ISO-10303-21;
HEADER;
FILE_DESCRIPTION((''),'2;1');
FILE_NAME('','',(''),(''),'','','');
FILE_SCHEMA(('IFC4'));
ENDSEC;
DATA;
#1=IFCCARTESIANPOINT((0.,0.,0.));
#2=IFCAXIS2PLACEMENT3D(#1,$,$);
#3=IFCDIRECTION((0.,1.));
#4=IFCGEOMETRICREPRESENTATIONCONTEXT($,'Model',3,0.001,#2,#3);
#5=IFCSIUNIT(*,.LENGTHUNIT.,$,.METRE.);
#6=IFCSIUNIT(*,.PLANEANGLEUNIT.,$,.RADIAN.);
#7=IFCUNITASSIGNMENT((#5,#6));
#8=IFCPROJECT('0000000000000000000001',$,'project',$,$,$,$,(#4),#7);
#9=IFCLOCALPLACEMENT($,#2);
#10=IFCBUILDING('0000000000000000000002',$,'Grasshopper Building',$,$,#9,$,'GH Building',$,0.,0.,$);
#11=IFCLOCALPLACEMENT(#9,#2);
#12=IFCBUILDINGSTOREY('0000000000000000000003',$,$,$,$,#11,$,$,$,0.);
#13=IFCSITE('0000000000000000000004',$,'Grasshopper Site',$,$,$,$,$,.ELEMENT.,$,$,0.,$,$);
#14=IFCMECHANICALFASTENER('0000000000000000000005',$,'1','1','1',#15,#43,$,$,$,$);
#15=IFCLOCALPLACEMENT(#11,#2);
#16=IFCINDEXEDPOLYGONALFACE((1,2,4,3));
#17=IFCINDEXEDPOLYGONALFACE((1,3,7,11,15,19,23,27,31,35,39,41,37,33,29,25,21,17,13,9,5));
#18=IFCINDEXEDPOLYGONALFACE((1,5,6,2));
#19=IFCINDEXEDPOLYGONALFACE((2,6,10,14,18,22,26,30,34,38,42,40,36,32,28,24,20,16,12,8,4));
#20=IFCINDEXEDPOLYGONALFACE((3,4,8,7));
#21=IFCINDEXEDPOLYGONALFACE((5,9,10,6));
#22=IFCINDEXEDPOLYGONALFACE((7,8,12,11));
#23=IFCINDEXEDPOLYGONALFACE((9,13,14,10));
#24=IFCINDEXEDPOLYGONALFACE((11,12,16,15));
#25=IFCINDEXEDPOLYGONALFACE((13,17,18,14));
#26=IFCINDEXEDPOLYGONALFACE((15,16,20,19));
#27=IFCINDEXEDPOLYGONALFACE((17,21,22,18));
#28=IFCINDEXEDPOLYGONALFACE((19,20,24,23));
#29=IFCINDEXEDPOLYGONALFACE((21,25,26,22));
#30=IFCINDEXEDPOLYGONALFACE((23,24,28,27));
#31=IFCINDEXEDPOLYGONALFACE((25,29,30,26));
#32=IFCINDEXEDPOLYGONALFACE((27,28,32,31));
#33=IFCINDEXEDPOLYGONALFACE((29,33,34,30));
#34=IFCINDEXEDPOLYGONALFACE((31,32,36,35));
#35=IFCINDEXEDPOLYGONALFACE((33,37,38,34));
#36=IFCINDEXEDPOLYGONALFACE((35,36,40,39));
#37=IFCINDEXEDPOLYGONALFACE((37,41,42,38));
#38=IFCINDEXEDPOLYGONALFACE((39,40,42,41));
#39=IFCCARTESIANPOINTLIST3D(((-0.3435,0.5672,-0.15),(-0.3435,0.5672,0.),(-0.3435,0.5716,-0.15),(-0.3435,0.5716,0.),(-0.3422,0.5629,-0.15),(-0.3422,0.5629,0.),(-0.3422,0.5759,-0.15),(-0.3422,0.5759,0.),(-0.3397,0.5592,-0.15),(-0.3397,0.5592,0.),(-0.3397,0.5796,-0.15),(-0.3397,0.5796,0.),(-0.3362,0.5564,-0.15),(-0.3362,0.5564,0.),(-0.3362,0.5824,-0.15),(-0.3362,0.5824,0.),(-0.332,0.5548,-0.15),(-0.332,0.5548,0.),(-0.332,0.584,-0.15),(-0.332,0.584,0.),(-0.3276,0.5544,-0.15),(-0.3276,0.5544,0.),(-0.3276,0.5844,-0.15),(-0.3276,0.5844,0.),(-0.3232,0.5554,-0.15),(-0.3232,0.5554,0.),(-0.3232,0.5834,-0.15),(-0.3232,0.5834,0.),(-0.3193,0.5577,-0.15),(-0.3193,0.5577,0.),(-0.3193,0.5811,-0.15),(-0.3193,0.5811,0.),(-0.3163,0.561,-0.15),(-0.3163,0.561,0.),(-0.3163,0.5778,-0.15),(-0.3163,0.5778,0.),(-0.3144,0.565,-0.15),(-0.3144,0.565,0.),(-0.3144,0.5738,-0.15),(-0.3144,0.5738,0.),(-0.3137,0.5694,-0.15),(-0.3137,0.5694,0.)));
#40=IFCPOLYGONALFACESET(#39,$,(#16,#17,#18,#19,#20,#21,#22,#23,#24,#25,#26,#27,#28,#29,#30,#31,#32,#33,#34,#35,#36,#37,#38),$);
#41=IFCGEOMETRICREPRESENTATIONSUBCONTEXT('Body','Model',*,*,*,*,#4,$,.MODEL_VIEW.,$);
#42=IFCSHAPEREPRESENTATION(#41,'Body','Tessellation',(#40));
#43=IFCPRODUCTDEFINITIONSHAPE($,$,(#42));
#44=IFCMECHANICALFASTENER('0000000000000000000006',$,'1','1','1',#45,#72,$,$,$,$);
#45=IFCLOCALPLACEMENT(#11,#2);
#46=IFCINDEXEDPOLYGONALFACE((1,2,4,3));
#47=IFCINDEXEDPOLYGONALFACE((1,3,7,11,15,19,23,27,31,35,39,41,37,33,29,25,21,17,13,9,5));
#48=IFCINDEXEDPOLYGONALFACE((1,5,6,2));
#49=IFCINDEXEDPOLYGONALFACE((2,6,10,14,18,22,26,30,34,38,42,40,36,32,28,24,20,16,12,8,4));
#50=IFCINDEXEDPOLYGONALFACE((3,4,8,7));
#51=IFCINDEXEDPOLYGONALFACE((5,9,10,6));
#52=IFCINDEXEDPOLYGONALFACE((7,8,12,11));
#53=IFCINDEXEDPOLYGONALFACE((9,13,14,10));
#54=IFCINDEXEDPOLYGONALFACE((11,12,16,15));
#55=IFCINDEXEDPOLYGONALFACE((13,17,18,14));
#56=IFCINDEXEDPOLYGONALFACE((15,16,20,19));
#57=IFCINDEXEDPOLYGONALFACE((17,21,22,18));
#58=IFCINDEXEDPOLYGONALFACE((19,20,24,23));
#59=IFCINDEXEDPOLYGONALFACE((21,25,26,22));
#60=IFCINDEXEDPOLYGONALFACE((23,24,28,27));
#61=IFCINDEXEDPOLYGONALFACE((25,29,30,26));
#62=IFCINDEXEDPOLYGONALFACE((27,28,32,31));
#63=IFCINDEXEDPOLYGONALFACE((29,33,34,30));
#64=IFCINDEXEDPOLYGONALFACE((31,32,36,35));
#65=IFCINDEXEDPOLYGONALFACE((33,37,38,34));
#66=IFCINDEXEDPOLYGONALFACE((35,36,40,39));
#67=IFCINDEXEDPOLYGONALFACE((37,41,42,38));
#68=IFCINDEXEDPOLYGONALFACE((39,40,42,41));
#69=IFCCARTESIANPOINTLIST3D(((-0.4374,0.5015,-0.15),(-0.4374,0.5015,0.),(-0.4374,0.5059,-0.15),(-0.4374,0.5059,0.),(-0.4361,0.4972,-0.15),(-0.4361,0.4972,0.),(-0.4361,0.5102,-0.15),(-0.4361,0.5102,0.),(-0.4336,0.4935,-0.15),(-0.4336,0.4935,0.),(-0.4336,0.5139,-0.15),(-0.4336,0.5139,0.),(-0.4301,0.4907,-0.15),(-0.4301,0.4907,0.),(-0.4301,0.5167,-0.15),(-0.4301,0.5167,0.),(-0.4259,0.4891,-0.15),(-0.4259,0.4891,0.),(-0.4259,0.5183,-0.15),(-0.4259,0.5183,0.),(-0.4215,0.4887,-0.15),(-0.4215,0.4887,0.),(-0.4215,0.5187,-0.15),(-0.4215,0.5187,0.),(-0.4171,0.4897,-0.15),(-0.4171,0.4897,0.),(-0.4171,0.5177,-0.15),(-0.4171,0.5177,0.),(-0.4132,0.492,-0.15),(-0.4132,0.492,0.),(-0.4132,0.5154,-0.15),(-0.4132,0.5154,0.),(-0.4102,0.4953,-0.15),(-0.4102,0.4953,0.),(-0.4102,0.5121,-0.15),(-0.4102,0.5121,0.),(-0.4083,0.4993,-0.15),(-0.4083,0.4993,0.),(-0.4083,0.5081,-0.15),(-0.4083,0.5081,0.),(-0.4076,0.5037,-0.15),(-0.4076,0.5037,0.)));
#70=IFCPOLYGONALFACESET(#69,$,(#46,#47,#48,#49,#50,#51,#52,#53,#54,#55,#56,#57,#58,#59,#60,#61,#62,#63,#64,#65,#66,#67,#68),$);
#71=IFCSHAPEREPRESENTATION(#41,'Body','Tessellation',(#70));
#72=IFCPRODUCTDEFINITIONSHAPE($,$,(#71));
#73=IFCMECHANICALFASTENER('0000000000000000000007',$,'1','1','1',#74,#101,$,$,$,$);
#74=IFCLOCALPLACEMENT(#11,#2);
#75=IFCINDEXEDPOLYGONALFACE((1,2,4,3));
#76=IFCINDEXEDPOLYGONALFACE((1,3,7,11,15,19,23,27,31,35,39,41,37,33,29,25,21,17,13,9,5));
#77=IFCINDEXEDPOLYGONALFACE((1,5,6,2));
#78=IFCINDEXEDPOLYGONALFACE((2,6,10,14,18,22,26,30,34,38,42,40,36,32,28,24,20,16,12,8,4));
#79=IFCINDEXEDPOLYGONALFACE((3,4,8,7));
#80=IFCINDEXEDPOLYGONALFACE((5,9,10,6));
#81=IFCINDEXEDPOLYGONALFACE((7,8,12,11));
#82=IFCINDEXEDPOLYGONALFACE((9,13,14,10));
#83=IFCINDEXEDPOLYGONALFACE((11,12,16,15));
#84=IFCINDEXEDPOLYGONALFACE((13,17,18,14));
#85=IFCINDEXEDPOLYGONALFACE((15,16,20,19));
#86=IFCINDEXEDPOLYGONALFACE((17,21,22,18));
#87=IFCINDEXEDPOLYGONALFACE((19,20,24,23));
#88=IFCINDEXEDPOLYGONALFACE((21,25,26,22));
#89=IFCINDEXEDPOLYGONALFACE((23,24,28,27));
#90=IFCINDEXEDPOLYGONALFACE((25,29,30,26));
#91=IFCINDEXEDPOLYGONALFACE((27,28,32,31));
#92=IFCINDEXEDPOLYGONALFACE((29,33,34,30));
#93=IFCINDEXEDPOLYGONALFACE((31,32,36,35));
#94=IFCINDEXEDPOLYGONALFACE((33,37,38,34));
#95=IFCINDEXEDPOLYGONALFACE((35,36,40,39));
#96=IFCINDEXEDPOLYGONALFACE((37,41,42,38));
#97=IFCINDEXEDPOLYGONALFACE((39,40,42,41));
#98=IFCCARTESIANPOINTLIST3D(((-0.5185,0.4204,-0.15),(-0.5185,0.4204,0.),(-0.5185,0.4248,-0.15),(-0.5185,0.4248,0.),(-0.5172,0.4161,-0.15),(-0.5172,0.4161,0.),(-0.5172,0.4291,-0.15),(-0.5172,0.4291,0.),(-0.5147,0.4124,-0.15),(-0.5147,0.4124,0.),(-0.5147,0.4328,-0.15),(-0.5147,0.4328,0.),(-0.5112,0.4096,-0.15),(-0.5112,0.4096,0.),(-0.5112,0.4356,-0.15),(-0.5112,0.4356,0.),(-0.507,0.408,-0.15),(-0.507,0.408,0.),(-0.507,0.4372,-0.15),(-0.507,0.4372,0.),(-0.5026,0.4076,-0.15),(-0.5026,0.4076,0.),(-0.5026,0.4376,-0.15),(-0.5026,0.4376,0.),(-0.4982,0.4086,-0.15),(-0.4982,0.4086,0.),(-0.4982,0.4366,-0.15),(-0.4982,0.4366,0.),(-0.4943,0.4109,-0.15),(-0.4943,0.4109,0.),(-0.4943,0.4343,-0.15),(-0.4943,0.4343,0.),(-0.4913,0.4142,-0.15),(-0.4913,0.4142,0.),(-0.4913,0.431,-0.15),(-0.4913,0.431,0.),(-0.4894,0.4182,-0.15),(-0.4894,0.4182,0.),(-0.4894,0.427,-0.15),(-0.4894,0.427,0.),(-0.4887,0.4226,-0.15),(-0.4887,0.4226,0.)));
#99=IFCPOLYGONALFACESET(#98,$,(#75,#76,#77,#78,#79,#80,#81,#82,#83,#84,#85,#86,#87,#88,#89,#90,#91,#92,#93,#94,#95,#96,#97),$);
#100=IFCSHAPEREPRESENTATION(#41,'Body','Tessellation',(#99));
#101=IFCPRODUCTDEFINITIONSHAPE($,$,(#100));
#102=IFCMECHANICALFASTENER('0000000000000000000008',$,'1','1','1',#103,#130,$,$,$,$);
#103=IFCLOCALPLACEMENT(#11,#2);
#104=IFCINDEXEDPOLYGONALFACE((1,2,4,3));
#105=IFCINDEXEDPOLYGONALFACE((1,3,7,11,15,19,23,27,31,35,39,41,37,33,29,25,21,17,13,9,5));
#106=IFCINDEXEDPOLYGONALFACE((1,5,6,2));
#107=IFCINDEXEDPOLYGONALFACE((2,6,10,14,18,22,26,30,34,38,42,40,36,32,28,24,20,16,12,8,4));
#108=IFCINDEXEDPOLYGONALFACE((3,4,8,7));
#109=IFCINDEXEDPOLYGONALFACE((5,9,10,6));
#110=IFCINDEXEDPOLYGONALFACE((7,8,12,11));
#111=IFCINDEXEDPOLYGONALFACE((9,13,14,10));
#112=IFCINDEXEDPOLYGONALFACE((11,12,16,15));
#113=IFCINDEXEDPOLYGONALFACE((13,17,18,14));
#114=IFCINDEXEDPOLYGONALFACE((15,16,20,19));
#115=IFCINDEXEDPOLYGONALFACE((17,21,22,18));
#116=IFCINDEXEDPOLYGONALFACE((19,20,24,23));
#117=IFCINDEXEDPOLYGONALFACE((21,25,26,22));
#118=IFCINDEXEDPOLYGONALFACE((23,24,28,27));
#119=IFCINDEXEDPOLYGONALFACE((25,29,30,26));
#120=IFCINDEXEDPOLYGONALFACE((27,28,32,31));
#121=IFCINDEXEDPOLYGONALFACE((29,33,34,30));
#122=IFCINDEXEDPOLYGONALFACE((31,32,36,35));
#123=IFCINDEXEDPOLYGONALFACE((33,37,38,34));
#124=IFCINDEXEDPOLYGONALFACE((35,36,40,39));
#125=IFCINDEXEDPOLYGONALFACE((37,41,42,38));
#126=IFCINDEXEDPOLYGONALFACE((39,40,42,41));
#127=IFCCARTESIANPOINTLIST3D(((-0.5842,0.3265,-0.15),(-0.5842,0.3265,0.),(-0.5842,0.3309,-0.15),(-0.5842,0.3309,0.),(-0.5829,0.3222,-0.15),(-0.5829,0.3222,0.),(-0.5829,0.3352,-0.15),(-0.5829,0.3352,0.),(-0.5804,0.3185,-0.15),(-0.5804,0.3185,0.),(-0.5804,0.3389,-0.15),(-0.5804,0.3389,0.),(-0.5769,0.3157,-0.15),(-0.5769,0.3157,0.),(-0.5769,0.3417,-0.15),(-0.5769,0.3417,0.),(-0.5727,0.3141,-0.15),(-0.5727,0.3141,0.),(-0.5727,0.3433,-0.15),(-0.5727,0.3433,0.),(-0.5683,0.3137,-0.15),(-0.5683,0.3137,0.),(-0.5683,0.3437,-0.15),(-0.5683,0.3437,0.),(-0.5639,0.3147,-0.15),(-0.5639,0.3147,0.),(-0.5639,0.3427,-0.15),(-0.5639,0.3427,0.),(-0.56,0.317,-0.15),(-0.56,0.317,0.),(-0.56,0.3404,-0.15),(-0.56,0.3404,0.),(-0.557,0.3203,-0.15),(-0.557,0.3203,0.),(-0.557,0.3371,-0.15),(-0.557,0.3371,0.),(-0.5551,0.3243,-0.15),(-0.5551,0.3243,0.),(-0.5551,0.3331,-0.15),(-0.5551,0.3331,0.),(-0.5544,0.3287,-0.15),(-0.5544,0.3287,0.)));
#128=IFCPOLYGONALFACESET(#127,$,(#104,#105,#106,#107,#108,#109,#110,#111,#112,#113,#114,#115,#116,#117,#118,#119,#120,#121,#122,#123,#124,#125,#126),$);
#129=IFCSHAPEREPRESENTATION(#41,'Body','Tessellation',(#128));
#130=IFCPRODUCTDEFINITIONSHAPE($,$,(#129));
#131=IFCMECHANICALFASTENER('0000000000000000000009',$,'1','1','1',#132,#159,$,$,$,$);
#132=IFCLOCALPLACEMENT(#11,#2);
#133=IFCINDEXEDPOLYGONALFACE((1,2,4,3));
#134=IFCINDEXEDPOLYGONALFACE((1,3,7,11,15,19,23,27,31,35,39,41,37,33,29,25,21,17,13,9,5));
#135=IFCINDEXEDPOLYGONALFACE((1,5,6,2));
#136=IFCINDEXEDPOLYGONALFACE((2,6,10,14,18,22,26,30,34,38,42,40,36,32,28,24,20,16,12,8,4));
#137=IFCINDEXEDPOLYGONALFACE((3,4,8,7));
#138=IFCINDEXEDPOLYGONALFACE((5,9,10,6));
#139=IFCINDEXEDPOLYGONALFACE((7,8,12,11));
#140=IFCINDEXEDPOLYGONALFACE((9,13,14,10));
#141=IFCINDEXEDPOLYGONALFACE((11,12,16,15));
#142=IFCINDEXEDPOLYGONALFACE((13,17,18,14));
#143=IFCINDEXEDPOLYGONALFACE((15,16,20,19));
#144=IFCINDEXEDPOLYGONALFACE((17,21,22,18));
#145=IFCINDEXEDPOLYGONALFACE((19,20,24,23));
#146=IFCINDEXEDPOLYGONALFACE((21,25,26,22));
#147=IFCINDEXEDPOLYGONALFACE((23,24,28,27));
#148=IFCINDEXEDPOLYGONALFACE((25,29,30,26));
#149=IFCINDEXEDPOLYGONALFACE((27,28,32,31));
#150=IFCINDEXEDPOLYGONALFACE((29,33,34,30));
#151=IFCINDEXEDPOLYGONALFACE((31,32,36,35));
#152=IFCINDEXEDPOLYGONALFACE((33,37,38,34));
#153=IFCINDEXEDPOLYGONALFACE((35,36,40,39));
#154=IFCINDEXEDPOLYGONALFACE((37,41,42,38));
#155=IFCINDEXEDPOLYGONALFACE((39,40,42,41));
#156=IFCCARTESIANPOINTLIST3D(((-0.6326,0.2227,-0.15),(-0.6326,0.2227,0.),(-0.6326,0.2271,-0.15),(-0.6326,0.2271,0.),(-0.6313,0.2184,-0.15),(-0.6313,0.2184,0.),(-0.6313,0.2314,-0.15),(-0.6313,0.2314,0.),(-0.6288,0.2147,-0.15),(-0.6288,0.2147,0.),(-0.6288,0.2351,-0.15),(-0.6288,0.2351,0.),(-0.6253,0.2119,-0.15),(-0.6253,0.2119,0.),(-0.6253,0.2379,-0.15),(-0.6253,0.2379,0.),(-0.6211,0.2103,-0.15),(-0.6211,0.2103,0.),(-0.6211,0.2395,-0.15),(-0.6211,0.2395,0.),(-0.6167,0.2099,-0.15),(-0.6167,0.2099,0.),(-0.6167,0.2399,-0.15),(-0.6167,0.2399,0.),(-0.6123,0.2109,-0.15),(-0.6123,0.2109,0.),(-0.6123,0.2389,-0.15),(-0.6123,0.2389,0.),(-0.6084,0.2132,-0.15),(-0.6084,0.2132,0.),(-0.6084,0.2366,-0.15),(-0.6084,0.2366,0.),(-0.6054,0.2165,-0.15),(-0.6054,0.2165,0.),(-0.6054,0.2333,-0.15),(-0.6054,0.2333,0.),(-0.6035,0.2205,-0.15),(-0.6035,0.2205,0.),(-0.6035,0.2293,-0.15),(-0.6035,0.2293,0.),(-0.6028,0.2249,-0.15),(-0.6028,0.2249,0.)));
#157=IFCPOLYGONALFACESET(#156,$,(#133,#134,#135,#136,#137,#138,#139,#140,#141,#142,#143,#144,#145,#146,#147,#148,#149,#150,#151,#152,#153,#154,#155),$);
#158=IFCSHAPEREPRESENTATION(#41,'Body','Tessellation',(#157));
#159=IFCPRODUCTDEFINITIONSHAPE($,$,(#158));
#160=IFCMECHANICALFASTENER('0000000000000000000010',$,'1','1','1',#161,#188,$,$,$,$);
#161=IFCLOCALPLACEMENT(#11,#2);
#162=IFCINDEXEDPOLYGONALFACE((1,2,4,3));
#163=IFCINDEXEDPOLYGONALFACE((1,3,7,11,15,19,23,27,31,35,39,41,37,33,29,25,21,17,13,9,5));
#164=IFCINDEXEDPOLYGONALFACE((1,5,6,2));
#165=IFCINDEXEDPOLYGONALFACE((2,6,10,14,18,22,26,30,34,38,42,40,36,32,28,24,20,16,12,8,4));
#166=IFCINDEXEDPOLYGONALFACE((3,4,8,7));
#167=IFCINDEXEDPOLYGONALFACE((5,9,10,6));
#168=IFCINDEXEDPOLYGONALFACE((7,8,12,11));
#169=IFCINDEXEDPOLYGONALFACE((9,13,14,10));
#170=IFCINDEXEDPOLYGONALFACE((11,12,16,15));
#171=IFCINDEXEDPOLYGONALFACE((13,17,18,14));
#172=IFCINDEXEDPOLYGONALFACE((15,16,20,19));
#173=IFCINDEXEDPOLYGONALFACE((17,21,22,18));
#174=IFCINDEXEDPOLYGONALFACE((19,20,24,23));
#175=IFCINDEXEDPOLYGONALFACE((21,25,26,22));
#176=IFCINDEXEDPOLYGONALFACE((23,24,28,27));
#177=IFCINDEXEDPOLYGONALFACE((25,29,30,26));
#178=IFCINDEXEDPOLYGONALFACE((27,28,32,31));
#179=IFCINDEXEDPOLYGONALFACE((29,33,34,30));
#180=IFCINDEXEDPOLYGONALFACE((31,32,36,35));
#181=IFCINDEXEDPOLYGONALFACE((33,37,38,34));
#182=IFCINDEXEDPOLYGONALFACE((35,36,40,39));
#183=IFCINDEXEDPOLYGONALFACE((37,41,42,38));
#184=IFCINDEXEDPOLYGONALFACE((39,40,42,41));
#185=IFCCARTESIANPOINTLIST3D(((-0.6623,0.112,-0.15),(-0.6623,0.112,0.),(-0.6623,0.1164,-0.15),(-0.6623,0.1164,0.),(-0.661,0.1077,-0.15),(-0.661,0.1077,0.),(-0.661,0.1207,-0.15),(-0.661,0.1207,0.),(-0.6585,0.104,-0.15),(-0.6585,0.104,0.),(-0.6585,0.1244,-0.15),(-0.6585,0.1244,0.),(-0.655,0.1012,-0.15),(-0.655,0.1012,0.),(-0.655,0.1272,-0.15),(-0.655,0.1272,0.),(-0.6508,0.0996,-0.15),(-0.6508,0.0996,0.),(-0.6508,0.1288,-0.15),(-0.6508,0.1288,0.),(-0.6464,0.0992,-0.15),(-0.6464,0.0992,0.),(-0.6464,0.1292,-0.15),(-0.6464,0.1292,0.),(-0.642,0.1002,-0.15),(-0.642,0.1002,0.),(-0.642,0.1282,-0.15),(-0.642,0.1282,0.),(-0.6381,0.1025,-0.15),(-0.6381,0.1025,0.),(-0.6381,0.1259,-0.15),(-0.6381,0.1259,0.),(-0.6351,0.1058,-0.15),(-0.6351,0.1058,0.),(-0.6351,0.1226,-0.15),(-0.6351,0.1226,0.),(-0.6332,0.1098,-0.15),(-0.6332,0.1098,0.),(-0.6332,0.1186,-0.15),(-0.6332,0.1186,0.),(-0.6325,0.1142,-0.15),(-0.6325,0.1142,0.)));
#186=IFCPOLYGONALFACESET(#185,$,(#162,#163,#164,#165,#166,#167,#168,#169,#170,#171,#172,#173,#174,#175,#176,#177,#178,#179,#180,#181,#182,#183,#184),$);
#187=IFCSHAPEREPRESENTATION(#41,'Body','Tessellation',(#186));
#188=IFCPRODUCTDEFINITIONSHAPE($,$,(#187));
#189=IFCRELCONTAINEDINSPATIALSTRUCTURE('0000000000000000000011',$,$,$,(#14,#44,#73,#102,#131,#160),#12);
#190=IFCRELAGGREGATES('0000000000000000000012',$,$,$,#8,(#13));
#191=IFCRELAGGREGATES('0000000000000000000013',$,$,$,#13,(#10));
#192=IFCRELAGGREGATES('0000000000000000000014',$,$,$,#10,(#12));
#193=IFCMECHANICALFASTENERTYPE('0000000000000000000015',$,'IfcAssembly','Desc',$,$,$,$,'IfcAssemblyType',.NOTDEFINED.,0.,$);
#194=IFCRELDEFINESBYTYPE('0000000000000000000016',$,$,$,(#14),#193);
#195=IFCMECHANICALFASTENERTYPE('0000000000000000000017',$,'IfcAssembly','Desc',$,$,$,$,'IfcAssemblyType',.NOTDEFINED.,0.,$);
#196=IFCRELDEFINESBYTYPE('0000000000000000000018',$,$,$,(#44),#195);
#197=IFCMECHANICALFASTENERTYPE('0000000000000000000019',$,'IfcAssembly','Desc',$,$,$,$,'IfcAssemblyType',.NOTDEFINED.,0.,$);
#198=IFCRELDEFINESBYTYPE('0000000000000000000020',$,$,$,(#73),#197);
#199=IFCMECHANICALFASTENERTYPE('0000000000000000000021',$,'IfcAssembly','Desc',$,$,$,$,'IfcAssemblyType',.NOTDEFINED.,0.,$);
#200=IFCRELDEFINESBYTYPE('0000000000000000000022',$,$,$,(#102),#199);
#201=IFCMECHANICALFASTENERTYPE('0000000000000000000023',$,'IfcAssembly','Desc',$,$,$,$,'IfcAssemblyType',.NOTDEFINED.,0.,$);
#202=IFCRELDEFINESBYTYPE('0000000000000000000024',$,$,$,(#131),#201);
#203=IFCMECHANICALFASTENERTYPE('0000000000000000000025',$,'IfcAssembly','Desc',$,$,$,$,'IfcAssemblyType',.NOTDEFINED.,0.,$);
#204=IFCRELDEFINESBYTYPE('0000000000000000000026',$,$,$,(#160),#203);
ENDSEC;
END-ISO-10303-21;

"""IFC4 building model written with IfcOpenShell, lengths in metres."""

from ifc_helpers import new_model, si_unit, direction, frame, origin, place, context, subcontext, project, spatial, circle, extrude, source, transform, mapped, type_object, type_shapes, element, save


model = new_model("IFC4")

# Units and contexts
model_context = context("Model", 3, precision=0.001, world=origin(), true_north=direction((0.0, 1.0)))
body_context = subcontext(model_context, "Body", "Model", "MODEL_VIEW")
ifc_project = project(units=[si_unit("LENGTHUNIT", "METRE"), si_unit("PLANEANGLEUNIT", "RADIAN")], contexts=[model_context])

# Site, building, storey
site = spatial("IfcSite", under=ifc_project, Name="Grasshopper Site", CompositionType="ELEMENT", RefElevation=0.0)
building_placement = place(None, origin())
building = spatial("IfcBuilding", under=site, at=building_placement, Name="Grasshopper Building", LongName="GH Building", ElevationOfRefHeight=0.0, ElevationOfTerrain=0.0)
storey_placement = place(building_placement, origin())
storey = spatial("IfcBuildingStorey", under=building, at=storey_placement, Elevation=0.0)

# Mechanical fasteners
mechanical_fastener_type_1 = type_object("IfcMechanicalFastenerType", Name="IfcAssembly", Description="Desc", ElementType="IfcAssemblyType", NominalDiameter=0.0)
shared_shape_1 = source(origin(), body_context, "Body", "SweptSolid", [
    extrude(circle(Radius=0.015), frame((-0.3287, 0.5694, 0.0), z_axis=(0.0, 0.0, -1.0), x_axis=(1.0, 0.0, 0.0)), (0.0, 0.0, 1.0), 0.15),
])
type_shapes(mechanical_fastener_type_1, [shared_shape_1])
mechanical_fastener_1_placement = place(storey_placement, origin())
element("IfcMechanicalFastener", 1, at=mechanical_fastener_1_placement, inside=storey, type_object=mechanical_fastener_type_1, Name="1", Description="1", ObjectType="1", context=body_context, shape_type="MappedRepresentation", body=[
    mapped(shared_shape_1, transform((0.0, 0.0, 0.0), scale=1.0)),
])
mechanical_fastener_type_2 = type_object("IfcMechanicalFastenerType", Name="IfcAssembly", Description="Desc", ElementType="IfcAssemblyType", NominalDiameter=0.0)
shared_shape_2 = source(origin(), body_context, "Body", "SweptSolid", [
    extrude(circle(Radius=0.015), frame((-0.4226, 0.5037, 0.0), z_axis=(0.0, 0.0, -1.0), x_axis=(1.0, 0.0, 0.0)), (0.0, 0.0, 1.0), 0.15),
])
type_shapes(mechanical_fastener_type_2, [shared_shape_2])
mechanical_fastener_2_placement = place(storey_placement, origin())
element("IfcMechanicalFastener", 2, at=mechanical_fastener_2_placement, inside=storey, type_object=mechanical_fastener_type_2, Name="1", Description="1", ObjectType="1", context=body_context, shape_type="MappedRepresentation", body=[
    mapped(shared_shape_2, transform((0.0, 0.0, 0.0), scale=1.0)),
])
mechanical_fastener_type_3 = type_object("IfcMechanicalFastenerType", Name="IfcAssembly", Description="Desc", ElementType="IfcAssemblyType", NominalDiameter=0.0)
shared_shape_3 = source(origin(), body_context, "Body", "SweptSolid", [
    extrude(circle(Radius=0.015), frame((-0.5037, 0.4226, 0.0), z_axis=(0.0, 0.0, -1.0), x_axis=(1.0, 0.0, 0.0)), (0.0, 0.0, 1.0), 0.15),
])
type_shapes(mechanical_fastener_type_3, [shared_shape_3])
mechanical_fastener_3_placement = place(storey_placement, origin())
element("IfcMechanicalFastener", 3, at=mechanical_fastener_3_placement, inside=storey, type_object=mechanical_fastener_type_3, Name="1", Description="1", ObjectType="1", context=body_context, shape_type="MappedRepresentation", body=[
    mapped(shared_shape_3, transform((0.0, 0.0, 0.0), scale=1.0)),
])
mechanical_fastener_type_4 = type_object("IfcMechanicalFastenerType", Name="IfcAssembly", Description="Desc", ElementType="IfcAssemblyType", NominalDiameter=0.0)
shared_shape_4 = source(origin(), body_context, "Body", "SweptSolid", [
    extrude(circle(Radius=0.015), frame((-0.5694, 0.3287, 0.0), z_axis=(0.0, 0.0, -1.0), x_axis=(1.0, 0.0, 0.0)), (0.0, 0.0, 1.0), 0.15),
])
type_shapes(mechanical_fastener_type_4, [shared_shape_4])
mechanical_fastener_4_placement = place(storey_placement, origin())
element("IfcMechanicalFastener", 4, at=mechanical_fastener_4_placement, inside=storey, type_object=mechanical_fastener_type_4, Name="1", Description="1", ObjectType="1", context=body_context, shape_type="MappedRepresentation", body=[
    mapped(shared_shape_4, transform((0.0, 0.0, 0.0), scale=1.0)),
])
mechanical_fastener_type_5 = type_object("IfcMechanicalFastenerType", Name="IfcAssembly", Description="Desc", ElementType="IfcAssemblyType", NominalDiameter=0.0)
shared_shape_5 = source(origin(), body_context, "Body", "SweptSolid", [
    extrude(circle(Radius=0.015), frame((-0.6178, 0.2249, 0.0), z_axis=(0.0, 0.0, -1.0), x_axis=(1.0, 0.0, 0.0)), (0.0, 0.0, 1.0), 0.15),
])
type_shapes(mechanical_fastener_type_5, [shared_shape_5])
mechanical_fastener_5_placement = place(storey_placement, origin())
element("IfcMechanicalFastener", 5, at=mechanical_fastener_5_placement, inside=storey, type_object=mechanical_fastener_type_5, Name="1", Description="1", ObjectType="1", context=body_context, shape_type="MappedRepresentation", body=[
    mapped(shared_shape_5, transform((0.0, 0.0, 0.0), scale=1.0)),
])
mechanical_fastener_type_6 = type_object("IfcMechanicalFastenerType", Name="IfcAssembly", Description="Desc", ElementType="IfcAssemblyType", NominalDiameter=0.0)
shared_shape_6 = source(origin(), body_context, "Body", "SweptSolid", [
    extrude(circle(Radius=0.015), frame((-0.6475, 0.1142, 0.0), z_axis=(0.0, 0.0, -1.0), x_axis=(1.0, 0.0, 0.0)), (0.0, 0.0, 1.0), 0.15),
])
type_shapes(mechanical_fastener_type_6, [shared_shape_6])
mechanical_fastener_6_placement = place(storey_placement, origin())
element("IfcMechanicalFastener", 6, at=mechanical_fastener_6_placement, inside=storey, type_object=mechanical_fastener_type_6, Name="1", Description="1", ObjectType="1", context=body_context, shape_type="MappedRepresentation", body=[
    mapped(shared_shape_6, transform((0.0, 0.0, 0.0), scale=1.0)),
])

save(model, "model.ifc")
